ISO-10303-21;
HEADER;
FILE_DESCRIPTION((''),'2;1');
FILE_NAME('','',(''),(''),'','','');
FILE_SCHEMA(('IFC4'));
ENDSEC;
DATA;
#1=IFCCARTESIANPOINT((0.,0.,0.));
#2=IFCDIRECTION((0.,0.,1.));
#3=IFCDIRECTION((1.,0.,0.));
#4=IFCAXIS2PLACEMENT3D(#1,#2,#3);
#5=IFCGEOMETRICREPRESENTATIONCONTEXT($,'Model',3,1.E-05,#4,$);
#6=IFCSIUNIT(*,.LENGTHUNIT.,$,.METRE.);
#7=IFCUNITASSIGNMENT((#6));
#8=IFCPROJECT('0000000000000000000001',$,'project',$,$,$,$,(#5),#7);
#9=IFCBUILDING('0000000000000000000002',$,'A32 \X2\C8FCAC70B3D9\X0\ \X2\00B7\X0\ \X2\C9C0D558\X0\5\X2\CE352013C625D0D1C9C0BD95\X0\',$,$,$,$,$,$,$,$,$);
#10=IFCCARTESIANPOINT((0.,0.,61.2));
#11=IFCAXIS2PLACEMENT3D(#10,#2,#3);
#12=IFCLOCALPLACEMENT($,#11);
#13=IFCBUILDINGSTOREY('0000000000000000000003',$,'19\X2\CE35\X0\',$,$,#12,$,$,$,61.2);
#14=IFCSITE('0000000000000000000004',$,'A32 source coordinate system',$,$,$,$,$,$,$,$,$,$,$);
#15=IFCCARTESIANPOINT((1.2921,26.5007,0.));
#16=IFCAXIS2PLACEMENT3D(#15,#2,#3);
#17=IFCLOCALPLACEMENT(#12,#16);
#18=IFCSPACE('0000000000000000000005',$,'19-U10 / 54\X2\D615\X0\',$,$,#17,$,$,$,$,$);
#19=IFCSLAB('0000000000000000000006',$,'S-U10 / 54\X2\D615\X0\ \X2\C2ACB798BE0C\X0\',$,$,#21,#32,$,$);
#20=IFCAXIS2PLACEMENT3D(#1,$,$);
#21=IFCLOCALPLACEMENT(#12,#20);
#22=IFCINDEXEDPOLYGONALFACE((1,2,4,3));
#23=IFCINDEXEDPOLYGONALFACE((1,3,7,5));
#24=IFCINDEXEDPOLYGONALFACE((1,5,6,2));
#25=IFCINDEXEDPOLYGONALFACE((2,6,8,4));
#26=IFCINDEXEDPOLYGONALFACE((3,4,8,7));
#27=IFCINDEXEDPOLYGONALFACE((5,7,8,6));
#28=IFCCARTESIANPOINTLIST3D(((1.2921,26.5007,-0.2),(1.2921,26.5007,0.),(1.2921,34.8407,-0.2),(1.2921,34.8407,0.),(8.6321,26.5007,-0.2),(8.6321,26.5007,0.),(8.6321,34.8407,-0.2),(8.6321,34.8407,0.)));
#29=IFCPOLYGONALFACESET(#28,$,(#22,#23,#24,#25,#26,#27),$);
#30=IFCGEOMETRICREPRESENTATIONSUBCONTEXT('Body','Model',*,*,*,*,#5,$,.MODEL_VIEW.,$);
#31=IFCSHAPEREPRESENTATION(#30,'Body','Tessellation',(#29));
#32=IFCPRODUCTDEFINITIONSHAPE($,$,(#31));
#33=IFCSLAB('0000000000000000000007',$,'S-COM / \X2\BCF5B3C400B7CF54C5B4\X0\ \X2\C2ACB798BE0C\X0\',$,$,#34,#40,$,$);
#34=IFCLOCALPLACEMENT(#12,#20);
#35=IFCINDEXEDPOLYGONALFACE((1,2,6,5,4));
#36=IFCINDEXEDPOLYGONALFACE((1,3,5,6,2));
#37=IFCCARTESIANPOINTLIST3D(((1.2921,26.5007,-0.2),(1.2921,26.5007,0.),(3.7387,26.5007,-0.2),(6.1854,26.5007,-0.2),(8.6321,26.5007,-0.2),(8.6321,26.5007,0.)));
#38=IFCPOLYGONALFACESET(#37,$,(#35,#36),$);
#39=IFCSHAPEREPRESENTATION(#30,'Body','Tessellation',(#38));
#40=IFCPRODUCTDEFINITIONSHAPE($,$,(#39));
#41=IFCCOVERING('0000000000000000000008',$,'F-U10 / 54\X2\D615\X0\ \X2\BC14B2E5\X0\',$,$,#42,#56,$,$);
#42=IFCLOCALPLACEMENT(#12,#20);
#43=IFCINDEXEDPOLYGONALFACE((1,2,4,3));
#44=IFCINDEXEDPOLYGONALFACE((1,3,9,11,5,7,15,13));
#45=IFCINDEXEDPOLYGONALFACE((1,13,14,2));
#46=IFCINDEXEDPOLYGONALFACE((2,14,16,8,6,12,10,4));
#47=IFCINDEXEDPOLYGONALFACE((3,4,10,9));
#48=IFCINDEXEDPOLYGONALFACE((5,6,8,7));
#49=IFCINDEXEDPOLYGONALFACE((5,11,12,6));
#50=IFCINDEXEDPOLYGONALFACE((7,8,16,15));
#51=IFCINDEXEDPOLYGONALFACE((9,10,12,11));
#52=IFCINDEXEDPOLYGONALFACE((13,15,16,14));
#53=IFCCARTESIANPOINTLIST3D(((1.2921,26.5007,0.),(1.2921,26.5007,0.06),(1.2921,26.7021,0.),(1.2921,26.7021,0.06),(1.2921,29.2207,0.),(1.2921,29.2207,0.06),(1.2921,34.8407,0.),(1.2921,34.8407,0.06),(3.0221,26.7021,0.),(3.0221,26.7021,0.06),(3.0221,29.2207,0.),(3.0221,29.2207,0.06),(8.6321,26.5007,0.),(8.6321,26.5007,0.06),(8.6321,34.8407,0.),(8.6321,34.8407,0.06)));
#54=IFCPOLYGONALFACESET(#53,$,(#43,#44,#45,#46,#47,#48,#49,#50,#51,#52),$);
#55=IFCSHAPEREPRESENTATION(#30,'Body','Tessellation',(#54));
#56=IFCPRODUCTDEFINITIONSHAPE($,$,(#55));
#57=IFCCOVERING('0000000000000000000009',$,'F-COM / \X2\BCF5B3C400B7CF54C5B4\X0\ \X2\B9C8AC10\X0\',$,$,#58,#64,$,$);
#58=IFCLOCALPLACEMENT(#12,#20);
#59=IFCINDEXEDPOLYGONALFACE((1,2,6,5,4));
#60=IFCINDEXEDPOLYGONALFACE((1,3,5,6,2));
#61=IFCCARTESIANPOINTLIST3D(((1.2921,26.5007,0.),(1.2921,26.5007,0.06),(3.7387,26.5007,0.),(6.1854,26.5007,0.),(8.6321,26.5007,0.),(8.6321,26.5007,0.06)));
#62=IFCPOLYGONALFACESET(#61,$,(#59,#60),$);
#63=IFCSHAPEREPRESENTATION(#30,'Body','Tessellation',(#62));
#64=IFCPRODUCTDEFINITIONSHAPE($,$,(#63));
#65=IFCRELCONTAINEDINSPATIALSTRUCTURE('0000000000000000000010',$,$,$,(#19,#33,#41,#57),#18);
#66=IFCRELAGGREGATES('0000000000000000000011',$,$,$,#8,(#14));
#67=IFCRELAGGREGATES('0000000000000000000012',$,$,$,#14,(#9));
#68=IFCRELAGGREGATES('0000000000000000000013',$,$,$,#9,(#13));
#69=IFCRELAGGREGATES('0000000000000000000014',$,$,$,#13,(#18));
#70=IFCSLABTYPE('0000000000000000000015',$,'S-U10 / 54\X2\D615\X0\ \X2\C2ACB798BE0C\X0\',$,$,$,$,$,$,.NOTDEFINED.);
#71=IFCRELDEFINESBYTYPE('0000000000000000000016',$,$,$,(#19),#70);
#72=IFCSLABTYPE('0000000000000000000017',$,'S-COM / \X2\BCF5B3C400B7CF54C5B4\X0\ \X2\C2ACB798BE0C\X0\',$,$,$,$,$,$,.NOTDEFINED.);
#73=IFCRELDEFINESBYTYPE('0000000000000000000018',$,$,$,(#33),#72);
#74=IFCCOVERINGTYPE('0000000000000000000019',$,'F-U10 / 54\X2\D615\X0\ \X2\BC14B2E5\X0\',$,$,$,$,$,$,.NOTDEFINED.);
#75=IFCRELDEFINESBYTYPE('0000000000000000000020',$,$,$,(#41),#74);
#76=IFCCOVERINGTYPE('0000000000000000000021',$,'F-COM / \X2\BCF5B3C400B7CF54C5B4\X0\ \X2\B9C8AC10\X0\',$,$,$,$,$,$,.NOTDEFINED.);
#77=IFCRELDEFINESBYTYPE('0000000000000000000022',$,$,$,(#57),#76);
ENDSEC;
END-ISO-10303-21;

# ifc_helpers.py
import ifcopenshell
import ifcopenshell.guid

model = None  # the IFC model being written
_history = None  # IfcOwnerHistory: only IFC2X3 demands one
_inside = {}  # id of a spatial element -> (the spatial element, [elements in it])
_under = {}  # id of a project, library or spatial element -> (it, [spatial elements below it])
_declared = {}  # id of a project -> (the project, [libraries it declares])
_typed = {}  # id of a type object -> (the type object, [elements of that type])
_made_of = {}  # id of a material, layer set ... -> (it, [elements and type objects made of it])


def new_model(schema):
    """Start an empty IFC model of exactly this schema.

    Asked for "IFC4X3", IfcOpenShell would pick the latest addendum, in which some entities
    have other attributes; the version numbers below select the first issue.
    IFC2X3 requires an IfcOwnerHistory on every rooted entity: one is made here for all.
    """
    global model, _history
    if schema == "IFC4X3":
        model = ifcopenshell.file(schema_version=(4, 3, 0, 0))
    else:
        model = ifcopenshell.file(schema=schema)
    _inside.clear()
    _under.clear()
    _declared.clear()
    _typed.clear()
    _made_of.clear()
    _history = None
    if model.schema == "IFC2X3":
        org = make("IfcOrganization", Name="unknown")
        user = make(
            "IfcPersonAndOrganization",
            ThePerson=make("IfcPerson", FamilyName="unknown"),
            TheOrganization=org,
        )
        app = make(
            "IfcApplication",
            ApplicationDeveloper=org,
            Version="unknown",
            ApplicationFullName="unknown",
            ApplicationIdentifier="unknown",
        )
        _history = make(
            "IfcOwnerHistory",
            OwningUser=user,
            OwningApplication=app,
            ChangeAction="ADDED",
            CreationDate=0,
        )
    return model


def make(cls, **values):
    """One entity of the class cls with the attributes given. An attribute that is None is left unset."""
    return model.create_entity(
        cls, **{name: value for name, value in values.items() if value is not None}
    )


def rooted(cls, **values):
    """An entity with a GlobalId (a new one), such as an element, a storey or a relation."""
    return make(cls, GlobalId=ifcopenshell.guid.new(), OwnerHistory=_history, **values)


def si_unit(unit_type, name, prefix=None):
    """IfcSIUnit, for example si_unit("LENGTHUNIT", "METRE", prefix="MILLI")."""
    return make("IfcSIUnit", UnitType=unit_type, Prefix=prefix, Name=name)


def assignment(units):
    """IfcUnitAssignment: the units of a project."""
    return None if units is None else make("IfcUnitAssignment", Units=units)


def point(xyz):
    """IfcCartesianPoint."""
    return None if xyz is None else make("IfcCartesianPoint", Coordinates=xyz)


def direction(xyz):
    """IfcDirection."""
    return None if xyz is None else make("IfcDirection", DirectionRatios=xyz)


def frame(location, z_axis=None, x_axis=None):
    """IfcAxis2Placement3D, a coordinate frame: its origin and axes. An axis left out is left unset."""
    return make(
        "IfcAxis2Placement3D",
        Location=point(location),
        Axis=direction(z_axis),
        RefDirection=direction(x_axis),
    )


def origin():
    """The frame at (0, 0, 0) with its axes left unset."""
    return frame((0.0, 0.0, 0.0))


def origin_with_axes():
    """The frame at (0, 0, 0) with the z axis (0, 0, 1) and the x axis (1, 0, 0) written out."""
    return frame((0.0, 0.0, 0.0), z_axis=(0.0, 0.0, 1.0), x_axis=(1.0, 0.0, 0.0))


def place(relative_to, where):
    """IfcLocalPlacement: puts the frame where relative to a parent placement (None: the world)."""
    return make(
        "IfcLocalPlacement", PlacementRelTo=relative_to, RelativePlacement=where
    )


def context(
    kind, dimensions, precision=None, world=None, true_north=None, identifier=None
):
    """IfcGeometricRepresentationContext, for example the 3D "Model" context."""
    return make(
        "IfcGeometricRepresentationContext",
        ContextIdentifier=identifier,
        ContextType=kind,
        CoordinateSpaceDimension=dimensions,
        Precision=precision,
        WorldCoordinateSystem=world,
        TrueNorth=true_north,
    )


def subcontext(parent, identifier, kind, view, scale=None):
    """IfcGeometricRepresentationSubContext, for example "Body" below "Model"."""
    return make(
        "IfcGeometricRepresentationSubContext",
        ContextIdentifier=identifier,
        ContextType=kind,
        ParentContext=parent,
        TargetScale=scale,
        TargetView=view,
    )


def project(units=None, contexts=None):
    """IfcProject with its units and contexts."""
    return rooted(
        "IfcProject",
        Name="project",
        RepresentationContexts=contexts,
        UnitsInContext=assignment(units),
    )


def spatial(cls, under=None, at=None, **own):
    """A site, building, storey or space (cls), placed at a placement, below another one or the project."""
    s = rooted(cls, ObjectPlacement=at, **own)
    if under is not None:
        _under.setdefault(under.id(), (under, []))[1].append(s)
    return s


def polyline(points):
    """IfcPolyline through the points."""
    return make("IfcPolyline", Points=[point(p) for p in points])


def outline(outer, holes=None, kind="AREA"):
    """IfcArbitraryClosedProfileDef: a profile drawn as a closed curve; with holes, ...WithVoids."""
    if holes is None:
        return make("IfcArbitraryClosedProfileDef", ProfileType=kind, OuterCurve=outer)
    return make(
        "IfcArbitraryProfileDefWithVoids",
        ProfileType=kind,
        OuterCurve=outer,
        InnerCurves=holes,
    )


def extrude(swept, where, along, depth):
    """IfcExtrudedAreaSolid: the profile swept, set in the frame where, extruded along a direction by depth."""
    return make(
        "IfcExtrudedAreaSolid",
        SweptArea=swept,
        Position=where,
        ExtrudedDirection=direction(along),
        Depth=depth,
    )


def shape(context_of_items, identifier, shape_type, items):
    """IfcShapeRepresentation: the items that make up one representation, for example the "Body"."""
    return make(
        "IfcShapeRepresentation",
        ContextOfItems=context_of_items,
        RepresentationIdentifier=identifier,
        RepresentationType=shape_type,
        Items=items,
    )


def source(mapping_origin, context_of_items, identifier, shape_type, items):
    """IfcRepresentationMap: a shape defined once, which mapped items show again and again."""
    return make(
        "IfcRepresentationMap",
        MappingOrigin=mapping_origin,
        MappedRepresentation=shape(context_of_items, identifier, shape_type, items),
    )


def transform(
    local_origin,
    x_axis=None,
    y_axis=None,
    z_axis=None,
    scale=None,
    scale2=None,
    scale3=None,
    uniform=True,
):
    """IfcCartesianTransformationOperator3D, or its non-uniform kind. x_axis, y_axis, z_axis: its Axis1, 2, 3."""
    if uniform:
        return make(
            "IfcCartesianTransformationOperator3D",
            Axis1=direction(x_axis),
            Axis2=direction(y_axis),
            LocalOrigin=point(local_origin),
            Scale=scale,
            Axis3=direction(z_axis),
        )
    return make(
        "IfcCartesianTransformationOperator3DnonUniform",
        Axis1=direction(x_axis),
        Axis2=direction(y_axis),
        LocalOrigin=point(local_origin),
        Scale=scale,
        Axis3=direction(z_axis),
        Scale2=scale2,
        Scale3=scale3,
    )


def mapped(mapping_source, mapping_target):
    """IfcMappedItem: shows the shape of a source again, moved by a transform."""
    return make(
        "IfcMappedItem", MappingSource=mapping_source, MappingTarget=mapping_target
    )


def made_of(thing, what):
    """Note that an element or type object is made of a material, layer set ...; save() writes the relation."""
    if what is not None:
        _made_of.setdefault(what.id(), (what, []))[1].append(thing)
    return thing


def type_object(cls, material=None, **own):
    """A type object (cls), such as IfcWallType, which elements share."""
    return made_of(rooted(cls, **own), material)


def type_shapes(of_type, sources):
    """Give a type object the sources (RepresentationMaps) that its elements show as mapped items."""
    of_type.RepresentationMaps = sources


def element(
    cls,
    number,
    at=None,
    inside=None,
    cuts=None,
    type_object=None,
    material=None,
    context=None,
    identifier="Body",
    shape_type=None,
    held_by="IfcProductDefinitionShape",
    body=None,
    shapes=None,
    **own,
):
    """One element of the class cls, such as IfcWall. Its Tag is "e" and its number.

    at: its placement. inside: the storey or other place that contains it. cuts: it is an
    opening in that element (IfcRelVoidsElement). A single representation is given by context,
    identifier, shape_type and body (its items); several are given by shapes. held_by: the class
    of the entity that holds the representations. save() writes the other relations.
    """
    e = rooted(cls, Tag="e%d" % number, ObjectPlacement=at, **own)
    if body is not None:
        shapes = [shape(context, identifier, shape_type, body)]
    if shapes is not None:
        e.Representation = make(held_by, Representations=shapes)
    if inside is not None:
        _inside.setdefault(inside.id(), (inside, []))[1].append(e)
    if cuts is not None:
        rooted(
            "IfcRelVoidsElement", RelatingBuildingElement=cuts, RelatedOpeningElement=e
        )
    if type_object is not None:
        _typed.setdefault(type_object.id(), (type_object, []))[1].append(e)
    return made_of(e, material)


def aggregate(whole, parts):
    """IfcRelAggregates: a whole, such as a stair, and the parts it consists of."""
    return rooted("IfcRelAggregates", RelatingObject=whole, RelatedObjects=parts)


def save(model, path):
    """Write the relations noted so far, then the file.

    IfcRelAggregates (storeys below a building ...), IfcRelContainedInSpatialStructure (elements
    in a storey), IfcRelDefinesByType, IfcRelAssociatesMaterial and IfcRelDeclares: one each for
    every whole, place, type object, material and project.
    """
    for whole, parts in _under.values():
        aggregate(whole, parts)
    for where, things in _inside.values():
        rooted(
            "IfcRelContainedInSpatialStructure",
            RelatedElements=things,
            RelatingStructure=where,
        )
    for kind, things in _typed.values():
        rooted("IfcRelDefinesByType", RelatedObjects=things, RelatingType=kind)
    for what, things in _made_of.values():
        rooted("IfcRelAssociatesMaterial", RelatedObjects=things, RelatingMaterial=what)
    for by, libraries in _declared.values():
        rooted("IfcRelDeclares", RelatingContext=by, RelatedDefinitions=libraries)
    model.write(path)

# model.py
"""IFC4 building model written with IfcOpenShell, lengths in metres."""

from ifc_helpers import new_model, si_unit, frame, origin, origin_with_axes, place, context, subcontext, project, spatial, polyline, outline, extrude, source, transform, mapped, type_object, type_shapes, element, save


model = new_model("IFC4")

# Units and contexts
model_context = context("Model", 3, precision=1e-05, world=origin_with_axes())
body_context = subcontext(model_context, "Body", "Model", "MODEL_VIEW")
ifc_project = project(units=[si_unit("LENGTHUNIT", "METRE")], contexts=[model_context])

# Site, building, storey, space
storey_placement = place(None, frame((0.0, 0.0, 61.2), z_axis=(0.0, 0.0, 1.0), x_axis=(1.0, 0.0, 0.0)))
space_placement = place(storey_placement, frame((1.2921, 26.5007, 0.0), z_axis=(0.0, 0.0, 1.0), x_axis=(1.0, 0.0, 0.0)))
site = spatial("IfcSite", under=ifc_project, Name="A32 source coordinate system")
building = spatial("IfcBuilding", under=site, Name="A32 주거동 · 지하5층–옥탑지붕")
storey = spatial("IfcBuildingStorey", under=building, at=storey_placement, Name="19층", Elevation=61.2)
space = spatial("IfcSpace", under=storey, at=space_placement, Name="19-U10 / 54형")

# Slabs
slab_type_1 = type_object("IfcSlabType", Name="S-U10 / 54형 슬래브", PredefinedType="NOTDEFINED")
shared_shape_1 = source(origin(), body_context, "Body", "SweptSolid", [
    extrude(outline(polyline([(0.0, 0.0), (0.0, 8.34), (7.34, 8.34), (7.34, 0.0), (0.0, 0.0)])), frame((0.0, 0.0, -0.2)), (0.0, 0.0, 1.0), 0.2),
])
type_shapes(slab_type_1, [shared_shape_1])
slab_1_placement = place(space_placement, origin_with_axes())
element("IfcSlab", 1, at=slab_1_placement, inside=space, type_object=slab_type_1, Name="S-U10 / 54형 슬래브", context=body_context, shape_type="MappedRepresentation", body=[
    mapped(shared_shape_1, transform((0.0, 0.0, 0.0), scale=1.0)),
])
slab_type_2 = type_object("IfcSlabType", Name="S-COM / 복도·코어 슬래브", PredefinedType="NOTDEFINED")
shared_shape_2 = source(origin(), body_context, "Body", "SweptSolid", [
    extrude(outline(polyline([(7.34, 0.0), (7.34, 0.0), (0.0, 0.0), (0.0, 0.0), (7.34, 0.0)])), frame((0.0, 0.0, -0.2)), (0.0, 0.0, 1.0), 0.2),
])
type_shapes(slab_type_2, [shared_shape_2])
slab_2_placement = place(space_placement, origin_with_axes())
element("IfcSlab", 2, at=slab_2_placement, inside=space, type_object=slab_type_2, Name="S-COM / 복도·코어 슬래브", context=body_context, shape_type="MappedRepresentation", body=[
    mapped(shared_shape_2, transform((0.0, 0.0, 0.0), scale=1.0)),
])

# Coverings
covering_type_1 = type_object("IfcCoveringType", Name="F-U10 / 54형 바닥", PredefinedType="NOTDEFINED")
shared_shape_3 = source(origin(), body_context, "Body", "SweptSolid", [
    extrude(outline(polyline([(7.34, 0.0), (0.0, 0.0), (0.0, 0.2014), (1.73, 0.2014), (1.73, 2.72), (0.0, 2.72), (0.0, 8.34), (7.34, 8.34), (7.34, 0.0)])), origin(), (0.0, 0.0, 1.0), 0.06),
])
type_shapes(covering_type_1, [shared_shape_3])
covering_1_placement = place(space_placement, origin_with_axes())
element("IfcCovering", 3, at=covering_1_placement, inside=space, type_object=covering_type_1, Name="F-U10 / 54형 바닥", context=body_context, shape_type="MappedRepresentation", body=[
    mapped(shared_shape_3, transform((0.0, 0.0, 0.0), scale=1.0)),
])
covering_type_2 = type_object("IfcCoveringType", Name="F-COM / 복도·코어 마감", PredefinedType="NOTDEFINED")
shared_shape_4 = source(origin(), body_context, "Body", "SweptSolid", [
    extrude(outline(polyline([(7.34, 0.0), (7.34, 0.0), (0.0, 0.0), (0.0, 0.0), (7.34, 0.0)])), origin(), (0.0, 0.0, 1.0), 0.06),
])
type_shapes(covering_type_2, [shared_shape_4])
covering_2_placement = place(space_placement, origin_with_axes())
element("IfcCovering", 4, at=covering_2_placement, inside=space, type_object=covering_type_2, Name="F-COM / 복도·코어 마감", context=body_context, shape_type="MappedRepresentation", body=[
    mapped(shared_shape_4, transform((0.0, 0.0, 0.0), scale=1.0)),
])

save(model, "model.ifc")
